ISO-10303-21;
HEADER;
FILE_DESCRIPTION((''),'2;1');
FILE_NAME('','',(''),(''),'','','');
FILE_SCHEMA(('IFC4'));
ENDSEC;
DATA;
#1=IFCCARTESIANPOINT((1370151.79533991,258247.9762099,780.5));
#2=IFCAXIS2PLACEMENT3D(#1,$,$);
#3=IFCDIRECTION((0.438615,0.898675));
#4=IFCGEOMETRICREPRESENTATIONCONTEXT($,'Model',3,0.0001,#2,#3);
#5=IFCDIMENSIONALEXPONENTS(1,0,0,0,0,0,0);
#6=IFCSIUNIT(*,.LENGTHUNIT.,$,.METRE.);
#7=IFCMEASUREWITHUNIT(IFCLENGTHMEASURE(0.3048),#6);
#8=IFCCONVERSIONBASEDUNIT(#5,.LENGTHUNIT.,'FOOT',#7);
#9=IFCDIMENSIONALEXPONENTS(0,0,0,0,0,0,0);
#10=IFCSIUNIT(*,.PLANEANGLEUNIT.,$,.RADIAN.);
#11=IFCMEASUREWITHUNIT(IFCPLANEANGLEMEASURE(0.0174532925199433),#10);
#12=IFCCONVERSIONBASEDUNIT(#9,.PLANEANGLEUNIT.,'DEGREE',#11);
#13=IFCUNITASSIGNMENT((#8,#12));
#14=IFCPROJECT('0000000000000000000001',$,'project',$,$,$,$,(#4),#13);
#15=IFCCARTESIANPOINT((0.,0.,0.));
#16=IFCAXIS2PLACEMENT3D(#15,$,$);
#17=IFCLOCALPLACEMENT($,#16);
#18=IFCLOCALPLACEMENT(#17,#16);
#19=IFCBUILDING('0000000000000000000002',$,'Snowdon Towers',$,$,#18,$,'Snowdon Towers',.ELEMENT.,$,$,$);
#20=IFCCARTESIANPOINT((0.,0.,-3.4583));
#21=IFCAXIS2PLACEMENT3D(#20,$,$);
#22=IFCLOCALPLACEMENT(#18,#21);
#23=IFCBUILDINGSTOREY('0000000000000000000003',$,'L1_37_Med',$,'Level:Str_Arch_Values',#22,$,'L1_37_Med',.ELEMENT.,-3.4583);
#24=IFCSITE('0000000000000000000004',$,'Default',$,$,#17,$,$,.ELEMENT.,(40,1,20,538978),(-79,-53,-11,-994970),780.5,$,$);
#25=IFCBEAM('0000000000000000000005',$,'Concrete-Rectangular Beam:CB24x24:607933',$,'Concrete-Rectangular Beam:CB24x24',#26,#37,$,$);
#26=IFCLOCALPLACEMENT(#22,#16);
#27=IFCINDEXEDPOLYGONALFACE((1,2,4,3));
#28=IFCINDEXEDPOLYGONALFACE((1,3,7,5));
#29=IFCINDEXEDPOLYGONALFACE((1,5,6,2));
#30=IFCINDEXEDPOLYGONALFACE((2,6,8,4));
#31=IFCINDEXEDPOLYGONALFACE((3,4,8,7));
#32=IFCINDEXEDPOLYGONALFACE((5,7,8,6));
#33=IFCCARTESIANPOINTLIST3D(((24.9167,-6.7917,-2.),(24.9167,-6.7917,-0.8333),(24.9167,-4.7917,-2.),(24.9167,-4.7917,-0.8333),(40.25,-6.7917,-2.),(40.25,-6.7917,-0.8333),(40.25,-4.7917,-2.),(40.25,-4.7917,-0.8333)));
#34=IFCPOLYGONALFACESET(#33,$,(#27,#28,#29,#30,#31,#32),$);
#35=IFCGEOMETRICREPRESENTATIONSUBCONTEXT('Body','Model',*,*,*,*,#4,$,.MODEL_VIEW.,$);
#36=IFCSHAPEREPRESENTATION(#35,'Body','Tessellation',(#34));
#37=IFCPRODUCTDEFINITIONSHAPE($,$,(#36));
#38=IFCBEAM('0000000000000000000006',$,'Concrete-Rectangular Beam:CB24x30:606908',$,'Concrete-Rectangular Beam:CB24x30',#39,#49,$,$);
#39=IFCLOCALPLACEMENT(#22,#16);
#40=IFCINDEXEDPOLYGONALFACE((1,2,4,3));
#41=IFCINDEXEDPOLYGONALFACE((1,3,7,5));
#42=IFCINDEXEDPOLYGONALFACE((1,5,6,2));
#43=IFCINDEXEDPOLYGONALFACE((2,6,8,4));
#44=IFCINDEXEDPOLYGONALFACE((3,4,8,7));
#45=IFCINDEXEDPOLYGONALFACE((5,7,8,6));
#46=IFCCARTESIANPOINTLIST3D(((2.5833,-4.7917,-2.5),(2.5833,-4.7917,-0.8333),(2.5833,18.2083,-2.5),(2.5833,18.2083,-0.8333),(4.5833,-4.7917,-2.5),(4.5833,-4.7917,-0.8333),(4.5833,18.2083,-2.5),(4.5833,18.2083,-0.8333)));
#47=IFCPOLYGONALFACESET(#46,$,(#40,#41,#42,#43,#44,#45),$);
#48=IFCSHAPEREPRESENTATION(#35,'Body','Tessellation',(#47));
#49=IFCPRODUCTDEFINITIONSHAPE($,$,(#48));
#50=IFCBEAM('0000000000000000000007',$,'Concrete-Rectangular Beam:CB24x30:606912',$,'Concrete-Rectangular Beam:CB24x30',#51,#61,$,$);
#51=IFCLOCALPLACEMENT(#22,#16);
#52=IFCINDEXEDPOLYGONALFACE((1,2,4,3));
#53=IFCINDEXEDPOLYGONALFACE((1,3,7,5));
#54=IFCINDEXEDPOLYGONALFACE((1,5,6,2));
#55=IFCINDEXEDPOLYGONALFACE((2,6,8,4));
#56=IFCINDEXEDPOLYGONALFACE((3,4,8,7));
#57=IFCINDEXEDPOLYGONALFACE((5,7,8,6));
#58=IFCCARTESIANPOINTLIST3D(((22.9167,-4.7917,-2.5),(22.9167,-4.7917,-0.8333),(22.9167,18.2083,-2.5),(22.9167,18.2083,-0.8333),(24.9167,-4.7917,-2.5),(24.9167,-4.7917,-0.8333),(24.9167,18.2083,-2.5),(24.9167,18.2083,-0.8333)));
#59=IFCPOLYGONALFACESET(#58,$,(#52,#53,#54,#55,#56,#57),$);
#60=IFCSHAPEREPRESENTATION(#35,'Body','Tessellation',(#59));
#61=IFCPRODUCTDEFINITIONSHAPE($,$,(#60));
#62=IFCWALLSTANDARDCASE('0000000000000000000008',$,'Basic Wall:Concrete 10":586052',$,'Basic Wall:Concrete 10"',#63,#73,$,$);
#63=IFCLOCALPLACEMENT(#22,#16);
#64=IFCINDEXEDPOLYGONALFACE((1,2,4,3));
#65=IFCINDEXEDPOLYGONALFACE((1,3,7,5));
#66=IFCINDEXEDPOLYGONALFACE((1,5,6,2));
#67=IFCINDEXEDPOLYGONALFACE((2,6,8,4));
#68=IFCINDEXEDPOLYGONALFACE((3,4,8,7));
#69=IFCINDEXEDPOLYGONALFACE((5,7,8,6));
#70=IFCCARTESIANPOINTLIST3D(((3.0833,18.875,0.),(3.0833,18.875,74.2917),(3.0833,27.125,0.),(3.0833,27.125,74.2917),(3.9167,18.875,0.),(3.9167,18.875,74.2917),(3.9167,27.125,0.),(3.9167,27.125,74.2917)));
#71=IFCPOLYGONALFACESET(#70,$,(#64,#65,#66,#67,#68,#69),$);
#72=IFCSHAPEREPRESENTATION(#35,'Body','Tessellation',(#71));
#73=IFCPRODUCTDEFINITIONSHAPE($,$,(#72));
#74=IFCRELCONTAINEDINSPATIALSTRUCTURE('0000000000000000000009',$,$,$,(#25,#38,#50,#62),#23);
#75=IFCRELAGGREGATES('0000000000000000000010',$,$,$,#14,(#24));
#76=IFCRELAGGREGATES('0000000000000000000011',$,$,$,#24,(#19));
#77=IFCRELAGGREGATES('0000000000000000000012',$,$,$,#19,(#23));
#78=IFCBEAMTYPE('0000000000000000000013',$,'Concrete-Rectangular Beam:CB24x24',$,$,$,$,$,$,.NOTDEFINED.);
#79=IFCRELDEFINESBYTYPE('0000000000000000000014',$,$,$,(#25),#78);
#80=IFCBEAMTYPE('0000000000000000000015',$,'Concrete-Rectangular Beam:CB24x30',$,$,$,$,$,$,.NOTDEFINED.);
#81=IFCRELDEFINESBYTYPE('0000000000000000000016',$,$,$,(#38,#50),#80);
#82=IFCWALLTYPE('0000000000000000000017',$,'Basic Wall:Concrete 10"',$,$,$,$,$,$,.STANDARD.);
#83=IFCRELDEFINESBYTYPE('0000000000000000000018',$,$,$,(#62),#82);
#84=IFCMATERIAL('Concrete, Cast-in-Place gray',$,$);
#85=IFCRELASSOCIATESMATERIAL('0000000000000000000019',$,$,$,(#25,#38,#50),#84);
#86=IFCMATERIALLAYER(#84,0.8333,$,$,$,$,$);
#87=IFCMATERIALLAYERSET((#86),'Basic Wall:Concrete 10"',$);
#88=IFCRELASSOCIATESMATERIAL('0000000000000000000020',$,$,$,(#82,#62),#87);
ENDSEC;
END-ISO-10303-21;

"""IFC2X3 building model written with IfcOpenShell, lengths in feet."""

from ifc_helpers import new_model, entity, si_unit, converted_unit, direction, frame, frame_2d, origin, place, context, subcontext, project, spatial, rectangle, extrude, material, layer, layer_set, layer_usage, type_object, element, save


model = new_model("IFC2X3")

# Units and contexts
model_context = context("Model", 3, precision=0.0001, world=frame((1370151.79533991, 258247.9762099, 780.5)), true_north=direction((0.438615, 0.898675)))
body_context = subcontext(model_context, "Body", "Model", "MODEL_VIEW")
ifc_project = project(units=[converted_unit("LENGTHUNIT", "FOOT", entity("IfcLengthMeasure", 0.3048), si_unit("LENGTHUNIT", "METRE"), dimensions=[1, 0, 0, 0, 0, 0, 0]), converted_unit("PLANEANGLEUNIT", "DEGREE", entity("IfcPlaneAngleMeasure", 0.0174532925199433), si_unit("PLANEANGLEUNIT", "RADIAN"), dimensions=[0, 0, 0, 0, 0, 0, 0])], contexts=[model_context])

# Site, building, storey
site_placement = place(None, origin())
site = spatial("IfcSite", under=ifc_project, at=site_placement, Name="Default", CompositionType="ELEMENT", RefLatitude=(40, 1, 20, 538978), RefLongitude=(-79, -53, -11, -994970), RefElevation=780.5)
building_placement = place(site_placement, origin())
building = spatial("IfcBuilding", under=site, at=building_placement, Name="Snowdon Towers", LongName="Snowdon Towers", CompositionType="ELEMENT")
storey_placement = place(building_placement, frame((0.0, 0.0, -3.4583)))
storey = spatial("IfcBuildingStorey", under=building, at=storey_placement, Name="L1_37_Med", ObjectType="Level:Str_Arch_Values", LongName="L1_37_Med", CompositionType="ELEMENT", Elevation=-3.4583)

# Beams
ifc_material_1 = material(Name="Concrete, Cast-in-Place gray")
beam_type_1 = type_object("IfcBeamType", Name="Concrete-Rectangular Beam:CB24x24", PredefinedType="NOTDEFINED")
beam_1_placement = place(storey_placement, frame((23.9167, -5.7917, 0.0)))
element("IfcBeam", 1, at=beam_1_placement, inside=storey, type_object=beam_type_1, material=ifc_material_1, Name="Concrete-Rectangular Beam:CB24x24:607933", ObjectType="Concrete-Rectangular Beam:CB24x24", context=body_context, shape_type="SweptSolid", body=[
    extrude(rectangle(XDim=1.1667, YDim=2.0, at=frame_2d((0.0, 0.0), x_axis=(1.0, 0.0))), frame((1.0, 0.0, -1.4167), z_axis=(1.0, 0.0, 0.0), x_axis=(0.0, 0.0, -1.0)), (0.0, 0.0, 1.0), 15.3333),
])
beam_type_2 = type_object("IfcBeamType", Name="Concrete-Rectangular Beam:CB24x30", PredefinedType="NOTDEFINED")
beam_2_placement = place(storey_placement, frame((3.5833, -5.7917, 0.0), z_axis=(0.0, 0.0, 1.0), x_axis=(0.0, 1.0, 0.0)))
element("IfcBeam", 2, at=beam_2_placement, inside=storey, type_object=beam_type_2, material=ifc_material_1, Name="Concrete-Rectangular Beam:CB24x30:606908", ObjectType="Concrete-Rectangular Beam:CB24x30", context=body_context, shape_type="SweptSolid", body=[
    extrude(rectangle(XDim=1.6667, YDim=2.0, at=frame_2d((0.0, 0.0), x_axis=(1.0, 0.0))), frame((1.0, 0.0, -1.6667), z_axis=(1.0, 0.0, 0.0), x_axis=(0.0, 0.0, -1.0)), (0.0, 0.0, 1.0), 23.0),
])
beam_3_placement = place(storey_placement, frame((23.9167, -5.7917, 0.0), z_axis=(0.0, 0.0, 1.0), x_axis=(0.0, 1.0, 0.0)))
element("IfcBeam", 3, at=beam_3_placement, inside=storey, type_object=beam_type_2, material=ifc_material_1, Name="Concrete-Rectangular Beam:CB24x30:606912", ObjectType="Concrete-Rectangular Beam:CB24x30", context=body_context, shape_type="SweptSolid", body=[
    extrude(rectangle(XDim=1.6667, YDim=2.0, at=frame_2d((0.0, 0.0), x_axis=(1.0, 0.0))), frame((1.0, 0.0, -1.6667), z_axis=(1.0, 0.0, 0.0), x_axis=(0.0, 0.0, -1.0)), (0.0, 0.0, 1.0), 23.0),
])

# Wall
ifc_layer_1 = layer(ifc_material_1, 0.8333)
ifc_layer_set_1 = layer_set([ifc_layer_1], Name="Basic Wall:Concrete 10\"")
ifc_layer_usage_1 = layer_usage(ifc_layer_set_1, "AXIS2", "POSITIVE", -0.4167)
wall_type = type_object("IfcWallType", Name="Basic Wall:Concrete 10\"", PredefinedType="STANDARD", material=ifc_layer_set_1)
wall_1_placement = place(storey_placement, frame((3.5, 27.125, 0.0), z_axis=(0.0, 0.0, 1.0), x_axis=(0.0, -1.0, 0.0)))
element("IfcWallStandardCase", 4, at=wall_1_placement, inside=storey, type_object=wall_type, material=ifc_layer_usage_1, Name="Basic Wall:Concrete 10\":586052", ObjectType="Basic Wall:Concrete 10\"", context=body_context, shape_type="SweptSolid", body=[
    extrude(rectangle(XDim=8.25, YDim=0.8333, at=frame_2d((4.125, 0.0), x_axis=(-1.0, 0.0))), origin(), (0.0, 0.0, 1.0), 74.2917),
])

save(model, "model.ifc")
